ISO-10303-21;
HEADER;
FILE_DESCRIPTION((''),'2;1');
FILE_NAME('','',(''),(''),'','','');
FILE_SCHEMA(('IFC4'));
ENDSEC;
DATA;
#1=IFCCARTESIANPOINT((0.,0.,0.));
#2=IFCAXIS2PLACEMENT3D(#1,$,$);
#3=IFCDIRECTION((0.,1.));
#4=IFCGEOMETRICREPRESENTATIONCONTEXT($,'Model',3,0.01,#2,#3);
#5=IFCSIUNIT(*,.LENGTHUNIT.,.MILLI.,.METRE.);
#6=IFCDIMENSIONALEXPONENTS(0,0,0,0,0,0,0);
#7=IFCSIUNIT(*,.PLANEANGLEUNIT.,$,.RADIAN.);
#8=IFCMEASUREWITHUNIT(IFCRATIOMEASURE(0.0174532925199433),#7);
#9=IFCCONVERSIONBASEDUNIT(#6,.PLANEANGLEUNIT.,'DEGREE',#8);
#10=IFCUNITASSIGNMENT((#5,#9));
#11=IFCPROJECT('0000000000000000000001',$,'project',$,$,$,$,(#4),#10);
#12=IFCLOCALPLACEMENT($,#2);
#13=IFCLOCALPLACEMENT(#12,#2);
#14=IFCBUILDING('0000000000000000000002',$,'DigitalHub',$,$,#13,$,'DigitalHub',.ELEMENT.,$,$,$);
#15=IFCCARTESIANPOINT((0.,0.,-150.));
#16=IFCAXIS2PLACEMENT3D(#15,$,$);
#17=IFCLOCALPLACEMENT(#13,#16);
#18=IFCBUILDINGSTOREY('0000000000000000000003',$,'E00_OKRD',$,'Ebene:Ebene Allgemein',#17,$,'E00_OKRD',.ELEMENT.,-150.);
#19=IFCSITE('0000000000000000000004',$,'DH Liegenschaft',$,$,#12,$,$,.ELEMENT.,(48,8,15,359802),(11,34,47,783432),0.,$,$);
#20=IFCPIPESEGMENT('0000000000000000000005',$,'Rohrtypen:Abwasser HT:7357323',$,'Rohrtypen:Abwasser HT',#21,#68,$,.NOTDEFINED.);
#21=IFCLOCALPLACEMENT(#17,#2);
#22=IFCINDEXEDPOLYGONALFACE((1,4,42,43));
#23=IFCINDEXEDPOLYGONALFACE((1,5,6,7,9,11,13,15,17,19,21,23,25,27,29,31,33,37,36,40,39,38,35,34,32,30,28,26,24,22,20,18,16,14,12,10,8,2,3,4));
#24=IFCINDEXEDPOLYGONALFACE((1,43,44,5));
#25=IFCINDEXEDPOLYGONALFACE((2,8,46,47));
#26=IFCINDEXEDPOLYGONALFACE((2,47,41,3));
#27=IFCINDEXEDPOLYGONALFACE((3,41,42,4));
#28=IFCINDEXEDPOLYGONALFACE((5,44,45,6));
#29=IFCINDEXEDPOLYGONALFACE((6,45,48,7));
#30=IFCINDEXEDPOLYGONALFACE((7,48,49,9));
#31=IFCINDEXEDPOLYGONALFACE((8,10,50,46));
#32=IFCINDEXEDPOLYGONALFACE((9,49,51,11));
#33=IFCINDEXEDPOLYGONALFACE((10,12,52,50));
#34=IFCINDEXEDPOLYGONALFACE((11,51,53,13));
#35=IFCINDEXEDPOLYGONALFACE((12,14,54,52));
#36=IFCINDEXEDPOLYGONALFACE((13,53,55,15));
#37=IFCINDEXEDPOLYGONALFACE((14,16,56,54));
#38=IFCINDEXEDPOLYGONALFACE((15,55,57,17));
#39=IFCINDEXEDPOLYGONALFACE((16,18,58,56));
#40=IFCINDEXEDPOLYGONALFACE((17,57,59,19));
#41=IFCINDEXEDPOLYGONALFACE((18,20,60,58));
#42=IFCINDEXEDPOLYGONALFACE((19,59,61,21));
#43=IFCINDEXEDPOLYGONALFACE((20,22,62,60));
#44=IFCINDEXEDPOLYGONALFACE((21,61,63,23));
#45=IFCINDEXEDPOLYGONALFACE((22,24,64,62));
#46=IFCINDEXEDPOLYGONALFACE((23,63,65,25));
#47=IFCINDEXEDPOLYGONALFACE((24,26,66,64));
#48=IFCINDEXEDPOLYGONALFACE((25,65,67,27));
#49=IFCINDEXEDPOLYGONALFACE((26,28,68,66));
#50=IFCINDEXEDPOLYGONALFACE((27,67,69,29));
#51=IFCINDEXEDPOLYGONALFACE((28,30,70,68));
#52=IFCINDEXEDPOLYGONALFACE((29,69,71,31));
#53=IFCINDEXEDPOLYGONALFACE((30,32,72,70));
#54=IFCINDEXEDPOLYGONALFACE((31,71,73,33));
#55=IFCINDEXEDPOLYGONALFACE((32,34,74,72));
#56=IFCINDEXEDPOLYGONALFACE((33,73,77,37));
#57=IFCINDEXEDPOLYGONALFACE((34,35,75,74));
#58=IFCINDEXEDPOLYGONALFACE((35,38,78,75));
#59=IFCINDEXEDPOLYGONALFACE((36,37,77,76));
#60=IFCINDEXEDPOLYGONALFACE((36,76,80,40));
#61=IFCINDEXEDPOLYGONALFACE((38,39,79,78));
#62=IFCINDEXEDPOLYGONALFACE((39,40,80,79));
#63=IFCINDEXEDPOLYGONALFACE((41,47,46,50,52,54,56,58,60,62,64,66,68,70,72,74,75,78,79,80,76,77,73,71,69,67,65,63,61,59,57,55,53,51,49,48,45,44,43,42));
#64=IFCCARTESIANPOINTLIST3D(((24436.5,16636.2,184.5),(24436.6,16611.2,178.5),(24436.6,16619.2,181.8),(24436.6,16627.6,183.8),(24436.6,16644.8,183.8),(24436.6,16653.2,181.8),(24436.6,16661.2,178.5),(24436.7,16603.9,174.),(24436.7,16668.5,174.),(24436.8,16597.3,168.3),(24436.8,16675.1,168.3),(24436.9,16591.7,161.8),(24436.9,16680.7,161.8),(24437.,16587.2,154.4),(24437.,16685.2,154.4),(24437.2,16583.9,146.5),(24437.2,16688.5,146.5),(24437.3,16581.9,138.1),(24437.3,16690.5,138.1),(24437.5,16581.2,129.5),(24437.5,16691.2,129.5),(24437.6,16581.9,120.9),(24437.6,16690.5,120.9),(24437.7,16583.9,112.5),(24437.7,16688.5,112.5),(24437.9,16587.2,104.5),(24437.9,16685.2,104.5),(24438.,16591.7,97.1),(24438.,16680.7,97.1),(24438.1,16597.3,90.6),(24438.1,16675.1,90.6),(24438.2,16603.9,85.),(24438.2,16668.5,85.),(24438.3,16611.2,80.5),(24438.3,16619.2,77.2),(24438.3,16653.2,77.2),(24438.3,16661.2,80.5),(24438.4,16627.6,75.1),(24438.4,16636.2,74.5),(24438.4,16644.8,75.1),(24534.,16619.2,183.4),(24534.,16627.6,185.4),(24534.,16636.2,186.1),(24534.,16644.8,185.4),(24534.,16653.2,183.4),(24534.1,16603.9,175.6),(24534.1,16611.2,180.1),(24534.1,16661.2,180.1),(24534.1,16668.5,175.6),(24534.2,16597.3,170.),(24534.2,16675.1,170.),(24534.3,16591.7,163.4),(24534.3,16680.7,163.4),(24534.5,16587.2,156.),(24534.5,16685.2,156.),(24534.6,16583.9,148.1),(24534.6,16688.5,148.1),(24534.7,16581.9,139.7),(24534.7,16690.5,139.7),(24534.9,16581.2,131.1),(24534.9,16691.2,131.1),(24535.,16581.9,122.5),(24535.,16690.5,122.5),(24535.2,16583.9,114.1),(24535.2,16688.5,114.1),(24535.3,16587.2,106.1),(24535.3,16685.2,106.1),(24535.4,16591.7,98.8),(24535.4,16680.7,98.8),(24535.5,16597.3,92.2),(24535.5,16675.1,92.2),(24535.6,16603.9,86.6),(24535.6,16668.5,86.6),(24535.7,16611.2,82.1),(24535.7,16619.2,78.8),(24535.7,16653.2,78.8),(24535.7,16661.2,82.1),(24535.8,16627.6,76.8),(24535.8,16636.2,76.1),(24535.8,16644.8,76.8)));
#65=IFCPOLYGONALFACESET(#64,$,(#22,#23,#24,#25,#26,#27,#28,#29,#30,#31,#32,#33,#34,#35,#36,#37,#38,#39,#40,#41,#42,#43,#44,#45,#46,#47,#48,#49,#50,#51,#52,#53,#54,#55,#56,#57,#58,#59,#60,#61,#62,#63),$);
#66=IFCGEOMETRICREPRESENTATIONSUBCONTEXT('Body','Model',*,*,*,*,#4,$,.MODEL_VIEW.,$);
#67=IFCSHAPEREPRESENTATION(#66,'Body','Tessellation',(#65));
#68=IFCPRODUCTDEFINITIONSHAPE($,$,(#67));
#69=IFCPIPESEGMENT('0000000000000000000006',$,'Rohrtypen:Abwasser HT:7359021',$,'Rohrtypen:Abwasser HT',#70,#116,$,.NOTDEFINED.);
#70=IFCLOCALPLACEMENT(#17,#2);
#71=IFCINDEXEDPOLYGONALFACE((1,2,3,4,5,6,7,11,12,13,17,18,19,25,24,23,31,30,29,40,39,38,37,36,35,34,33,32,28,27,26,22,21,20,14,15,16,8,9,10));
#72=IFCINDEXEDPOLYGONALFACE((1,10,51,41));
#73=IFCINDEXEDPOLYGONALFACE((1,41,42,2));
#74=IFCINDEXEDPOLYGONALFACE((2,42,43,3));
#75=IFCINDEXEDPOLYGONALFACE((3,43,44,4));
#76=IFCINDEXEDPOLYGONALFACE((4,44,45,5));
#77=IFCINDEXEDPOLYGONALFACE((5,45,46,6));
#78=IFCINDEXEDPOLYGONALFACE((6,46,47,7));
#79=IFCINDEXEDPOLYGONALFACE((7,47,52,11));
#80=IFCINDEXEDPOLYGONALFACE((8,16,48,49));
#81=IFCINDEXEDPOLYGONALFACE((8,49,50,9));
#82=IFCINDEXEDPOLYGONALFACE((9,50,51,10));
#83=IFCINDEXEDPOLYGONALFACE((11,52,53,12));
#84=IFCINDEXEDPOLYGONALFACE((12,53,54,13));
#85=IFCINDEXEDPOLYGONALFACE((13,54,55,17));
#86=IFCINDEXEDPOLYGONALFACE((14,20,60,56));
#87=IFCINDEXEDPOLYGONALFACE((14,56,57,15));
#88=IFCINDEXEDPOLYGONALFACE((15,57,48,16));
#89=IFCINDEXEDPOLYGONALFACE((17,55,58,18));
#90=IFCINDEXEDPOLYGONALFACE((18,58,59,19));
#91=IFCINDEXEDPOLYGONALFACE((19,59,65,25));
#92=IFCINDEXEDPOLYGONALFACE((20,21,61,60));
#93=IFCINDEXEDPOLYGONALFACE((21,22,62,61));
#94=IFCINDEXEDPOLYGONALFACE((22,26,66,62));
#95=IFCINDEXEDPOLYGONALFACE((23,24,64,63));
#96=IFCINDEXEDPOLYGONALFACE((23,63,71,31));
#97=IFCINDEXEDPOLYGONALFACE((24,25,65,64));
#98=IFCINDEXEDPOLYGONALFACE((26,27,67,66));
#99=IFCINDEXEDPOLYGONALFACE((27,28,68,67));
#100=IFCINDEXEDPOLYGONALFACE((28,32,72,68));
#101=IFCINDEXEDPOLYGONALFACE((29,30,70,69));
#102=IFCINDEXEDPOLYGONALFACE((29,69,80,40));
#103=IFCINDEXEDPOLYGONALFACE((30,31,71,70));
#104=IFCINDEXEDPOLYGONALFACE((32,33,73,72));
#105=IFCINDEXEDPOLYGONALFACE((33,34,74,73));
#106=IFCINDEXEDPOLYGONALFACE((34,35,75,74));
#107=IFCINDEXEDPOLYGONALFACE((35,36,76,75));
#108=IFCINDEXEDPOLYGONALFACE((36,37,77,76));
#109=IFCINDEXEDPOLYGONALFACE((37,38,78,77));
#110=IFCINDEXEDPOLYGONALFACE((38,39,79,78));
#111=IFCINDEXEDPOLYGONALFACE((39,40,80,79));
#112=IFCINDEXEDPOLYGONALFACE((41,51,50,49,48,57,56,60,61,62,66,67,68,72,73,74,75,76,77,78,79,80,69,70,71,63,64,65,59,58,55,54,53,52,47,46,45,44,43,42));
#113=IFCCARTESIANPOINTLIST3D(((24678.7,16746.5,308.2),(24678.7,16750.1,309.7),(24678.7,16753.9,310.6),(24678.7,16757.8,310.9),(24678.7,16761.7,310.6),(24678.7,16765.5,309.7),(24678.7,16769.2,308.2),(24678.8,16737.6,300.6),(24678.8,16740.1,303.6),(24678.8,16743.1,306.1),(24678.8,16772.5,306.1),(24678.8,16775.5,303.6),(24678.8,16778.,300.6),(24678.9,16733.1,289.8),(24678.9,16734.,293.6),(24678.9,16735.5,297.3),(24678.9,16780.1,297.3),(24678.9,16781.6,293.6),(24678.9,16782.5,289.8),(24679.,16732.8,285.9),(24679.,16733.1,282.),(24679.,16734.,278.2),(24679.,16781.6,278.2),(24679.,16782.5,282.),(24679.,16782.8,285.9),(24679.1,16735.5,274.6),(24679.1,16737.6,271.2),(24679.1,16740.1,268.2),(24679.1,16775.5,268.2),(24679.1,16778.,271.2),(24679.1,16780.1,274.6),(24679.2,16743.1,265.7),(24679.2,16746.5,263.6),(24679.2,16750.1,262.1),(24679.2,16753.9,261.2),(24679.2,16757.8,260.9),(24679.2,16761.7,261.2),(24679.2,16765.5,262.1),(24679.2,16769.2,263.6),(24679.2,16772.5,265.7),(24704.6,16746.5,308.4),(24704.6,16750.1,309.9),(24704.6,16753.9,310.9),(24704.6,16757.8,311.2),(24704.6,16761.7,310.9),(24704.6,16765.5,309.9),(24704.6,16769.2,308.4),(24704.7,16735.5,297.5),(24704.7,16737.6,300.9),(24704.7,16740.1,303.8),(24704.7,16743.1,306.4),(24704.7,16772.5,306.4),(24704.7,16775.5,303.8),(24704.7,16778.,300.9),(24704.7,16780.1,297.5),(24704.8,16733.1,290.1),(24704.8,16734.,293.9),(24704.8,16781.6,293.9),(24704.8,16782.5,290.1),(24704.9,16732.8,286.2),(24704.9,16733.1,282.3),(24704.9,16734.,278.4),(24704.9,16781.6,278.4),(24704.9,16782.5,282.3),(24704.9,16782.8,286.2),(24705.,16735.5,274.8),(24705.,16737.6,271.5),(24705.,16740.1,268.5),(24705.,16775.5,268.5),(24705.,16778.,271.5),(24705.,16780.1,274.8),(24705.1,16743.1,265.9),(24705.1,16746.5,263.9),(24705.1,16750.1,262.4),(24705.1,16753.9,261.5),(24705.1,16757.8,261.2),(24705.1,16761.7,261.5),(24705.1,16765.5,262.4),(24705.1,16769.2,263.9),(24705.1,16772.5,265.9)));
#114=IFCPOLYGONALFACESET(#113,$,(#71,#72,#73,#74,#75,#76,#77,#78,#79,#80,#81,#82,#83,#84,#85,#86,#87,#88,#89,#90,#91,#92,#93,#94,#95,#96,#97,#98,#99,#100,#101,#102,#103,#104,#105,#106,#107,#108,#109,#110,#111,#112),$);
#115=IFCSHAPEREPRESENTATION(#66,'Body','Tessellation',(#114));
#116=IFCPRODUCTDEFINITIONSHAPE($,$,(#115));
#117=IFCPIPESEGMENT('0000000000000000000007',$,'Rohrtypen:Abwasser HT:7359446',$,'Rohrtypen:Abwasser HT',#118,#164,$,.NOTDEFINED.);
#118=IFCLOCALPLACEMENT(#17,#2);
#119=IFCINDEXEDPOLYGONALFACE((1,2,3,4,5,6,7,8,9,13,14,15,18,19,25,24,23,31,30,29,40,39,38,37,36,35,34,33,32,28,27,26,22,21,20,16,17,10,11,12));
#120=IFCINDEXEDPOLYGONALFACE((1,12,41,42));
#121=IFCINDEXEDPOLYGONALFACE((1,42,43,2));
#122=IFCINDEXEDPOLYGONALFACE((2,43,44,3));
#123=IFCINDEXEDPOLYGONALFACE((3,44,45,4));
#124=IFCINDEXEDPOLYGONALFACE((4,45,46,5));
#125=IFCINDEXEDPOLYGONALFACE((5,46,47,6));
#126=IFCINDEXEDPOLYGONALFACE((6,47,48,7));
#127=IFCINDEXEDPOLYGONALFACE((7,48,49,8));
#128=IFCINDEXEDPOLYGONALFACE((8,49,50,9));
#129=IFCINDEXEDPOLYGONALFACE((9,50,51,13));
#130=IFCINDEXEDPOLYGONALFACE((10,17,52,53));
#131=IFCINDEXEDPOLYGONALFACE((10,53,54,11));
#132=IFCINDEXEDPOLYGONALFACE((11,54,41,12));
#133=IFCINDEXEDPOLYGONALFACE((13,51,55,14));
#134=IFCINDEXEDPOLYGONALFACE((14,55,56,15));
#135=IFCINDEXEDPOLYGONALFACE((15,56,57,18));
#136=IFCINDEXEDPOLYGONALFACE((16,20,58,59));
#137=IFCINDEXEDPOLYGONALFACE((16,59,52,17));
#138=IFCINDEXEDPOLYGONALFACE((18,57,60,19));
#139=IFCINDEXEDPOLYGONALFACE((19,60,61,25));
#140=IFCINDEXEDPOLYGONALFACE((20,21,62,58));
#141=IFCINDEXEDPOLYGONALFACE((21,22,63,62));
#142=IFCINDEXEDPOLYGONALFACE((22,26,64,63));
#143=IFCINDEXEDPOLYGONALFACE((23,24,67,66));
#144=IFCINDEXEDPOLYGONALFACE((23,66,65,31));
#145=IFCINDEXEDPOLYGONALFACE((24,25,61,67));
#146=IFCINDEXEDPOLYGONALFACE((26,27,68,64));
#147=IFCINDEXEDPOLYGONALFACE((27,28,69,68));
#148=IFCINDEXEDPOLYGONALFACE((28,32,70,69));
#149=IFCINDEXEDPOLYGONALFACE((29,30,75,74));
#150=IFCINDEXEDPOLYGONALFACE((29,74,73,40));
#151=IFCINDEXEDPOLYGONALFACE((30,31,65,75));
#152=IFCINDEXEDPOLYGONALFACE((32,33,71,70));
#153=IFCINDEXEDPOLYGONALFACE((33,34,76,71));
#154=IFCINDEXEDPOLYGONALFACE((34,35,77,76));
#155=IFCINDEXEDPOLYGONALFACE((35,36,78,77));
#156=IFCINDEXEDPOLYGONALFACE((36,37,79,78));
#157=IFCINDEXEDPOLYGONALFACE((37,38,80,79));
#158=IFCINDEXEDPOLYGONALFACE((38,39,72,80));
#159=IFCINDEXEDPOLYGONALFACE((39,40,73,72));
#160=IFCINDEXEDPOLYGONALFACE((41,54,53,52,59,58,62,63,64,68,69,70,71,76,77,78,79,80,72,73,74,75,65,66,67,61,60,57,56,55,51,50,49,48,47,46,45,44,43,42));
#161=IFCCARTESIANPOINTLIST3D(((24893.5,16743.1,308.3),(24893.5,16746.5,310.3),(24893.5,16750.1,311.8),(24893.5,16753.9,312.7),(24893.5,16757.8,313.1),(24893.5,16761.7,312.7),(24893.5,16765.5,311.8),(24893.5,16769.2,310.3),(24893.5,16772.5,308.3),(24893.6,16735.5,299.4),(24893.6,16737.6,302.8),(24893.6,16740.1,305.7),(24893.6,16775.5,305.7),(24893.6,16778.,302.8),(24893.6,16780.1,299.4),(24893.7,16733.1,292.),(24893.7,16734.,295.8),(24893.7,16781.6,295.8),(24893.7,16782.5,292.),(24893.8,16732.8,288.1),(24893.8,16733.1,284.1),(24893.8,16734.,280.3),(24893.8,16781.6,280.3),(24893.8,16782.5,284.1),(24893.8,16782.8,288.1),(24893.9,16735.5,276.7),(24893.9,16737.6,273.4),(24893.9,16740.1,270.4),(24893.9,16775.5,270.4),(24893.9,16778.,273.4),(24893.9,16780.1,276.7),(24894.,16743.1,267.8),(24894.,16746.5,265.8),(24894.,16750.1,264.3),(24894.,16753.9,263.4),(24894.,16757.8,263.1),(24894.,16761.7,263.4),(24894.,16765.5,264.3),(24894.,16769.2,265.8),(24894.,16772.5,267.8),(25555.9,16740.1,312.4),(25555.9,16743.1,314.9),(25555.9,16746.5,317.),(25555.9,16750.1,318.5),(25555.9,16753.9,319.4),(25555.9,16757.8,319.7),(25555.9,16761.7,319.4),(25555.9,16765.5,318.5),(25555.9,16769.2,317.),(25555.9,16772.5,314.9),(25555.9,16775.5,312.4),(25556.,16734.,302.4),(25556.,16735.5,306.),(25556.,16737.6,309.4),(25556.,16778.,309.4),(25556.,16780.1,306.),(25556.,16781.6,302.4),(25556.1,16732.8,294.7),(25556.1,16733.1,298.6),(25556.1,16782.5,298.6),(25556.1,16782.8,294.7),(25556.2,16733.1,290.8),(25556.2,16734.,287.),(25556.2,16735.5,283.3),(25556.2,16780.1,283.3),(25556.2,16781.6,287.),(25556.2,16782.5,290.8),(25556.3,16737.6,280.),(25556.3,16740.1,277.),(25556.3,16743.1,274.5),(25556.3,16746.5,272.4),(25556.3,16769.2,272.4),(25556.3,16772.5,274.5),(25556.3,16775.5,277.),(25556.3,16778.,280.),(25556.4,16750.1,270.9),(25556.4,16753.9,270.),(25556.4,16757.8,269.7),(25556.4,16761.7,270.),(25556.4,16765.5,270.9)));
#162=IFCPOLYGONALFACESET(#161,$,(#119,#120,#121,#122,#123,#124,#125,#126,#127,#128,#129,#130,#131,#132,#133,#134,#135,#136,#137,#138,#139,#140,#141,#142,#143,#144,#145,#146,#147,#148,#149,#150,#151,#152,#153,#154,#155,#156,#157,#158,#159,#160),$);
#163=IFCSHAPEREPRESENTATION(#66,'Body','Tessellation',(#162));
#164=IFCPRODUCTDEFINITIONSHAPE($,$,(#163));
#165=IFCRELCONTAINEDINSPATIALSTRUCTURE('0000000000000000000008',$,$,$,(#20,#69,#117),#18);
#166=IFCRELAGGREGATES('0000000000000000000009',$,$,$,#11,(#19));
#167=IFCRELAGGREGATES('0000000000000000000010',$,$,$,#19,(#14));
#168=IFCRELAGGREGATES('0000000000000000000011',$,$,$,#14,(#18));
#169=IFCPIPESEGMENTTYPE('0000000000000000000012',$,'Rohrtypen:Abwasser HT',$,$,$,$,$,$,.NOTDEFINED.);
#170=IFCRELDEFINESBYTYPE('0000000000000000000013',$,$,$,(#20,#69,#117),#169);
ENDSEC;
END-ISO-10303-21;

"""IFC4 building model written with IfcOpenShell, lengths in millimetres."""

from ifc_helpers import new_model, entity, si_unit, converted_unit, direction, frame, origin, place, context, subcontext, project, spatial, indexed_curve, outline, extrude, type_object, element, save


model = new_model("IFC4")

# Units and contexts
model_context = context("Model", 3, precision=0.01, world=origin(), true_north=direction((0.0, 1.0)))
body_context = subcontext(model_context, "Body", "Model", "MODEL_VIEW")
ifc_project = project(units=[si_unit("LENGTHUNIT", "METRE", prefix="MILLI"), converted_unit("PLANEANGLEUNIT", "DEGREE", entity("IfcRatioMeasure", 0.0174532925199433), si_unit("PLANEANGLEUNIT", "RADIAN"), dimensions=[0, 0, 0, 0, 0, 0, 0])], contexts=[model_context])

# Site, building, storey
site_placement = place(None, origin())
site = spatial("IfcSite", under=ifc_project, at=site_placement, Name="DH Liegenschaft", CompositionType="ELEMENT", RefLatitude=(48, 8, 15, 359802), RefLongitude=(11, 34, 47, 783432), RefElevation=0.0)
building_placement = place(site_placement, origin())
building = spatial("IfcBuilding", under=site, at=building_placement, Name="DigitalHub", LongName="DigitalHub", CompositionType="ELEMENT")
storey_placement = place(building_placement, frame((0.0, 0.0, -150.0)))
storey = spatial("IfcBuildingStorey", under=building, at=storey_placement, Name="E00_OKRD", ObjectType="Ebene:Ebene Allgemein", LongName="E00_OKRD", CompositionType="ELEMENT", Elevation=-150.0)

# Pipe segments
pipe_segment_type_1 = type_object("IfcPipeSegmentType", Name="Rohrtypen:Abwasser HT", PredefinedType="NOTDEFINED")
pipe_segment_1_placement = place(storey_placement, frame((24434.9, 16579.6, 72.9)))
element("IfcPipeSegment", 1, at=pipe_segment_1_placement, inside=storey, type_object=pipe_segment_type_1, Name="Rohrtypen:Abwasser HT:7357323", ObjectType="Rohrtypen:Abwasser HT", PredefinedType="NOTDEFINED", context=body_context, shape_type="SweptSolid", body=[
    extrude(outline(indexed_curve([(55.0, 0.0), (54.3, 8.6), (52.3, 17.0), (49.0, 25.0), (44.5, 32.3), (38.9, 38.9), (32.3, 44.5), (25.0, 49.0), (17.0, 52.3), (8.6, 54.3), (0.0, 55.0), (-8.6, 54.3), (-17.0, 52.3), (-25.0, 49.0), (-32.3, 44.5), (-38.9, 38.9), (-44.5, 32.3), (-49.0, 25.0), (-52.3, 17.0), (-54.3, 8.6), (-55.0, 0.0), (-54.3, -8.6), (-52.3, -17.0), (-49.0, -25.0), (-44.5, -32.3), (-38.9, -38.9), (-32.3, -44.5), (-25.0, -49.0), (-17.0, -52.3), (-8.6, -54.3), (0.0, -55.0), (8.6, -54.3), (17.0, -52.3), (25.0, -49.0), (32.3, -44.5), (38.9, -38.9), (44.5, -32.3), (49.0, -25.0), (52.3, -17.0), (54.3, -8.6), (55.0, 0.0)], self_intersect=False)), frame((2.5, 56.6, 56.6), z_axis=(0.999862, 0.0, 0.016604), x_axis=(0.0, -1.0, 0.0)), (0.0, 0.0, 1.0), 97.4),
])
pipe_segment_2_placement = place(storey_placement, frame((24677.1, 16731.2, 259.3)))
element("IfcPipeSegment", 2, at=pipe_segment_2_placement, inside=storey, type_object=pipe_segment_type_1, Name="Rohrtypen:Abwasser HT:7359021", ObjectType="Rohrtypen:Abwasser HT", PredefinedType="NOTDEFINED", context=body_context, shape_type="SweptSolid", body=[
    extrude(outline(indexed_curve([(25.0, 0.0), (24.7, 3.9), (23.8, 7.7), (22.3, 11.3), (20.2, 14.7), (17.7, 17.7), (14.7, 20.2), (11.3, 22.3), (7.7, 23.8), (3.9, 24.7), (0.0, 25.0), (-3.9, 24.7), (-7.7, 23.8), (-11.3, 22.3), (-14.7, 20.2), (-17.7, 17.7), (-20.2, 14.7), (-22.3, 11.3), (-23.8, 7.7), (-24.7, 3.9), (-25.0, 0.0), (-24.7, -3.9), (-23.8, -7.7), (-22.3, -11.3), (-20.2, -14.7), (-17.7, -17.7), (-14.7, -20.2), (-11.3, -22.3), (-7.7, -23.8), (-3.9, -24.7), (0.0, -25.0), (3.9, -24.7), (7.7, -23.8), (11.3, -22.3), (14.7, -20.2), (17.7, -17.7), (20.2, -14.7), (22.3, -11.3), (23.8, -7.7), (24.7, -3.9), (25.0, 0.0)], self_intersect=False)), frame((1.8, 26.6, 26.6), z_axis=(0.99995, 0.0, 0.01), x_axis=(0.0, 1.0, 0.0)), (0.0, 0.0, 1.0), 25.9),
])
pipe_segment_3_placement = place(storey_placement, frame((24891.9, 16731.2, 261.5)))
element("IfcPipeSegment", 3, at=pipe_segment_3_placement, inside=storey, type_object=pipe_segment_type_1, Name="Rohrtypen:Abwasser HT:7359446", ObjectType="Rohrtypen:Abwasser HT", PredefinedType="NOTDEFINED", context=body_context, shape_type="SweptSolid", body=[
    extrude(outline(indexed_curve([(25.0, 0.0), (24.7, 3.9), (23.8, 7.7), (22.3, 11.3), (20.2, 14.7), (17.7, 17.7), (14.7, 20.2), (11.3, 22.3), (7.7, 23.8), (3.9, 24.7), (0.0, 25.0), (-3.9, 24.7), (-7.7, 23.8), (-11.3, 22.3), (-14.7, 20.2), (-17.7, 17.7), (-20.2, 14.7), (-22.3, 11.3), (-23.8, 7.7), (-24.7, 3.9), (-25.0, 0.0), (-24.7, -3.9), (-23.8, -7.7), (-22.3, -11.3), (-20.2, -14.7), (-17.7, -17.7), (-14.7, -20.2), (-11.3, -22.3), (-7.7, -23.8), (-3.9, -24.7), (0.0, -25.0), (3.9, -24.7), (7.7, -23.8), (11.3, -22.3), (14.7, -20.2), (17.7, -17.7), (20.2, -14.7), (22.3, -11.3), (23.8, -7.7), (24.7, -3.9), (25.0, 0.0)], self_intersect=False)), frame((1.8, 26.6, 26.6), z_axis=(0.99995, 0.0, 0.01), x_axis=(0.0, 1.0, 0.0)), (0.0, 0.0, 1.0), 662.4),
])

save(model, "model.ifc")
